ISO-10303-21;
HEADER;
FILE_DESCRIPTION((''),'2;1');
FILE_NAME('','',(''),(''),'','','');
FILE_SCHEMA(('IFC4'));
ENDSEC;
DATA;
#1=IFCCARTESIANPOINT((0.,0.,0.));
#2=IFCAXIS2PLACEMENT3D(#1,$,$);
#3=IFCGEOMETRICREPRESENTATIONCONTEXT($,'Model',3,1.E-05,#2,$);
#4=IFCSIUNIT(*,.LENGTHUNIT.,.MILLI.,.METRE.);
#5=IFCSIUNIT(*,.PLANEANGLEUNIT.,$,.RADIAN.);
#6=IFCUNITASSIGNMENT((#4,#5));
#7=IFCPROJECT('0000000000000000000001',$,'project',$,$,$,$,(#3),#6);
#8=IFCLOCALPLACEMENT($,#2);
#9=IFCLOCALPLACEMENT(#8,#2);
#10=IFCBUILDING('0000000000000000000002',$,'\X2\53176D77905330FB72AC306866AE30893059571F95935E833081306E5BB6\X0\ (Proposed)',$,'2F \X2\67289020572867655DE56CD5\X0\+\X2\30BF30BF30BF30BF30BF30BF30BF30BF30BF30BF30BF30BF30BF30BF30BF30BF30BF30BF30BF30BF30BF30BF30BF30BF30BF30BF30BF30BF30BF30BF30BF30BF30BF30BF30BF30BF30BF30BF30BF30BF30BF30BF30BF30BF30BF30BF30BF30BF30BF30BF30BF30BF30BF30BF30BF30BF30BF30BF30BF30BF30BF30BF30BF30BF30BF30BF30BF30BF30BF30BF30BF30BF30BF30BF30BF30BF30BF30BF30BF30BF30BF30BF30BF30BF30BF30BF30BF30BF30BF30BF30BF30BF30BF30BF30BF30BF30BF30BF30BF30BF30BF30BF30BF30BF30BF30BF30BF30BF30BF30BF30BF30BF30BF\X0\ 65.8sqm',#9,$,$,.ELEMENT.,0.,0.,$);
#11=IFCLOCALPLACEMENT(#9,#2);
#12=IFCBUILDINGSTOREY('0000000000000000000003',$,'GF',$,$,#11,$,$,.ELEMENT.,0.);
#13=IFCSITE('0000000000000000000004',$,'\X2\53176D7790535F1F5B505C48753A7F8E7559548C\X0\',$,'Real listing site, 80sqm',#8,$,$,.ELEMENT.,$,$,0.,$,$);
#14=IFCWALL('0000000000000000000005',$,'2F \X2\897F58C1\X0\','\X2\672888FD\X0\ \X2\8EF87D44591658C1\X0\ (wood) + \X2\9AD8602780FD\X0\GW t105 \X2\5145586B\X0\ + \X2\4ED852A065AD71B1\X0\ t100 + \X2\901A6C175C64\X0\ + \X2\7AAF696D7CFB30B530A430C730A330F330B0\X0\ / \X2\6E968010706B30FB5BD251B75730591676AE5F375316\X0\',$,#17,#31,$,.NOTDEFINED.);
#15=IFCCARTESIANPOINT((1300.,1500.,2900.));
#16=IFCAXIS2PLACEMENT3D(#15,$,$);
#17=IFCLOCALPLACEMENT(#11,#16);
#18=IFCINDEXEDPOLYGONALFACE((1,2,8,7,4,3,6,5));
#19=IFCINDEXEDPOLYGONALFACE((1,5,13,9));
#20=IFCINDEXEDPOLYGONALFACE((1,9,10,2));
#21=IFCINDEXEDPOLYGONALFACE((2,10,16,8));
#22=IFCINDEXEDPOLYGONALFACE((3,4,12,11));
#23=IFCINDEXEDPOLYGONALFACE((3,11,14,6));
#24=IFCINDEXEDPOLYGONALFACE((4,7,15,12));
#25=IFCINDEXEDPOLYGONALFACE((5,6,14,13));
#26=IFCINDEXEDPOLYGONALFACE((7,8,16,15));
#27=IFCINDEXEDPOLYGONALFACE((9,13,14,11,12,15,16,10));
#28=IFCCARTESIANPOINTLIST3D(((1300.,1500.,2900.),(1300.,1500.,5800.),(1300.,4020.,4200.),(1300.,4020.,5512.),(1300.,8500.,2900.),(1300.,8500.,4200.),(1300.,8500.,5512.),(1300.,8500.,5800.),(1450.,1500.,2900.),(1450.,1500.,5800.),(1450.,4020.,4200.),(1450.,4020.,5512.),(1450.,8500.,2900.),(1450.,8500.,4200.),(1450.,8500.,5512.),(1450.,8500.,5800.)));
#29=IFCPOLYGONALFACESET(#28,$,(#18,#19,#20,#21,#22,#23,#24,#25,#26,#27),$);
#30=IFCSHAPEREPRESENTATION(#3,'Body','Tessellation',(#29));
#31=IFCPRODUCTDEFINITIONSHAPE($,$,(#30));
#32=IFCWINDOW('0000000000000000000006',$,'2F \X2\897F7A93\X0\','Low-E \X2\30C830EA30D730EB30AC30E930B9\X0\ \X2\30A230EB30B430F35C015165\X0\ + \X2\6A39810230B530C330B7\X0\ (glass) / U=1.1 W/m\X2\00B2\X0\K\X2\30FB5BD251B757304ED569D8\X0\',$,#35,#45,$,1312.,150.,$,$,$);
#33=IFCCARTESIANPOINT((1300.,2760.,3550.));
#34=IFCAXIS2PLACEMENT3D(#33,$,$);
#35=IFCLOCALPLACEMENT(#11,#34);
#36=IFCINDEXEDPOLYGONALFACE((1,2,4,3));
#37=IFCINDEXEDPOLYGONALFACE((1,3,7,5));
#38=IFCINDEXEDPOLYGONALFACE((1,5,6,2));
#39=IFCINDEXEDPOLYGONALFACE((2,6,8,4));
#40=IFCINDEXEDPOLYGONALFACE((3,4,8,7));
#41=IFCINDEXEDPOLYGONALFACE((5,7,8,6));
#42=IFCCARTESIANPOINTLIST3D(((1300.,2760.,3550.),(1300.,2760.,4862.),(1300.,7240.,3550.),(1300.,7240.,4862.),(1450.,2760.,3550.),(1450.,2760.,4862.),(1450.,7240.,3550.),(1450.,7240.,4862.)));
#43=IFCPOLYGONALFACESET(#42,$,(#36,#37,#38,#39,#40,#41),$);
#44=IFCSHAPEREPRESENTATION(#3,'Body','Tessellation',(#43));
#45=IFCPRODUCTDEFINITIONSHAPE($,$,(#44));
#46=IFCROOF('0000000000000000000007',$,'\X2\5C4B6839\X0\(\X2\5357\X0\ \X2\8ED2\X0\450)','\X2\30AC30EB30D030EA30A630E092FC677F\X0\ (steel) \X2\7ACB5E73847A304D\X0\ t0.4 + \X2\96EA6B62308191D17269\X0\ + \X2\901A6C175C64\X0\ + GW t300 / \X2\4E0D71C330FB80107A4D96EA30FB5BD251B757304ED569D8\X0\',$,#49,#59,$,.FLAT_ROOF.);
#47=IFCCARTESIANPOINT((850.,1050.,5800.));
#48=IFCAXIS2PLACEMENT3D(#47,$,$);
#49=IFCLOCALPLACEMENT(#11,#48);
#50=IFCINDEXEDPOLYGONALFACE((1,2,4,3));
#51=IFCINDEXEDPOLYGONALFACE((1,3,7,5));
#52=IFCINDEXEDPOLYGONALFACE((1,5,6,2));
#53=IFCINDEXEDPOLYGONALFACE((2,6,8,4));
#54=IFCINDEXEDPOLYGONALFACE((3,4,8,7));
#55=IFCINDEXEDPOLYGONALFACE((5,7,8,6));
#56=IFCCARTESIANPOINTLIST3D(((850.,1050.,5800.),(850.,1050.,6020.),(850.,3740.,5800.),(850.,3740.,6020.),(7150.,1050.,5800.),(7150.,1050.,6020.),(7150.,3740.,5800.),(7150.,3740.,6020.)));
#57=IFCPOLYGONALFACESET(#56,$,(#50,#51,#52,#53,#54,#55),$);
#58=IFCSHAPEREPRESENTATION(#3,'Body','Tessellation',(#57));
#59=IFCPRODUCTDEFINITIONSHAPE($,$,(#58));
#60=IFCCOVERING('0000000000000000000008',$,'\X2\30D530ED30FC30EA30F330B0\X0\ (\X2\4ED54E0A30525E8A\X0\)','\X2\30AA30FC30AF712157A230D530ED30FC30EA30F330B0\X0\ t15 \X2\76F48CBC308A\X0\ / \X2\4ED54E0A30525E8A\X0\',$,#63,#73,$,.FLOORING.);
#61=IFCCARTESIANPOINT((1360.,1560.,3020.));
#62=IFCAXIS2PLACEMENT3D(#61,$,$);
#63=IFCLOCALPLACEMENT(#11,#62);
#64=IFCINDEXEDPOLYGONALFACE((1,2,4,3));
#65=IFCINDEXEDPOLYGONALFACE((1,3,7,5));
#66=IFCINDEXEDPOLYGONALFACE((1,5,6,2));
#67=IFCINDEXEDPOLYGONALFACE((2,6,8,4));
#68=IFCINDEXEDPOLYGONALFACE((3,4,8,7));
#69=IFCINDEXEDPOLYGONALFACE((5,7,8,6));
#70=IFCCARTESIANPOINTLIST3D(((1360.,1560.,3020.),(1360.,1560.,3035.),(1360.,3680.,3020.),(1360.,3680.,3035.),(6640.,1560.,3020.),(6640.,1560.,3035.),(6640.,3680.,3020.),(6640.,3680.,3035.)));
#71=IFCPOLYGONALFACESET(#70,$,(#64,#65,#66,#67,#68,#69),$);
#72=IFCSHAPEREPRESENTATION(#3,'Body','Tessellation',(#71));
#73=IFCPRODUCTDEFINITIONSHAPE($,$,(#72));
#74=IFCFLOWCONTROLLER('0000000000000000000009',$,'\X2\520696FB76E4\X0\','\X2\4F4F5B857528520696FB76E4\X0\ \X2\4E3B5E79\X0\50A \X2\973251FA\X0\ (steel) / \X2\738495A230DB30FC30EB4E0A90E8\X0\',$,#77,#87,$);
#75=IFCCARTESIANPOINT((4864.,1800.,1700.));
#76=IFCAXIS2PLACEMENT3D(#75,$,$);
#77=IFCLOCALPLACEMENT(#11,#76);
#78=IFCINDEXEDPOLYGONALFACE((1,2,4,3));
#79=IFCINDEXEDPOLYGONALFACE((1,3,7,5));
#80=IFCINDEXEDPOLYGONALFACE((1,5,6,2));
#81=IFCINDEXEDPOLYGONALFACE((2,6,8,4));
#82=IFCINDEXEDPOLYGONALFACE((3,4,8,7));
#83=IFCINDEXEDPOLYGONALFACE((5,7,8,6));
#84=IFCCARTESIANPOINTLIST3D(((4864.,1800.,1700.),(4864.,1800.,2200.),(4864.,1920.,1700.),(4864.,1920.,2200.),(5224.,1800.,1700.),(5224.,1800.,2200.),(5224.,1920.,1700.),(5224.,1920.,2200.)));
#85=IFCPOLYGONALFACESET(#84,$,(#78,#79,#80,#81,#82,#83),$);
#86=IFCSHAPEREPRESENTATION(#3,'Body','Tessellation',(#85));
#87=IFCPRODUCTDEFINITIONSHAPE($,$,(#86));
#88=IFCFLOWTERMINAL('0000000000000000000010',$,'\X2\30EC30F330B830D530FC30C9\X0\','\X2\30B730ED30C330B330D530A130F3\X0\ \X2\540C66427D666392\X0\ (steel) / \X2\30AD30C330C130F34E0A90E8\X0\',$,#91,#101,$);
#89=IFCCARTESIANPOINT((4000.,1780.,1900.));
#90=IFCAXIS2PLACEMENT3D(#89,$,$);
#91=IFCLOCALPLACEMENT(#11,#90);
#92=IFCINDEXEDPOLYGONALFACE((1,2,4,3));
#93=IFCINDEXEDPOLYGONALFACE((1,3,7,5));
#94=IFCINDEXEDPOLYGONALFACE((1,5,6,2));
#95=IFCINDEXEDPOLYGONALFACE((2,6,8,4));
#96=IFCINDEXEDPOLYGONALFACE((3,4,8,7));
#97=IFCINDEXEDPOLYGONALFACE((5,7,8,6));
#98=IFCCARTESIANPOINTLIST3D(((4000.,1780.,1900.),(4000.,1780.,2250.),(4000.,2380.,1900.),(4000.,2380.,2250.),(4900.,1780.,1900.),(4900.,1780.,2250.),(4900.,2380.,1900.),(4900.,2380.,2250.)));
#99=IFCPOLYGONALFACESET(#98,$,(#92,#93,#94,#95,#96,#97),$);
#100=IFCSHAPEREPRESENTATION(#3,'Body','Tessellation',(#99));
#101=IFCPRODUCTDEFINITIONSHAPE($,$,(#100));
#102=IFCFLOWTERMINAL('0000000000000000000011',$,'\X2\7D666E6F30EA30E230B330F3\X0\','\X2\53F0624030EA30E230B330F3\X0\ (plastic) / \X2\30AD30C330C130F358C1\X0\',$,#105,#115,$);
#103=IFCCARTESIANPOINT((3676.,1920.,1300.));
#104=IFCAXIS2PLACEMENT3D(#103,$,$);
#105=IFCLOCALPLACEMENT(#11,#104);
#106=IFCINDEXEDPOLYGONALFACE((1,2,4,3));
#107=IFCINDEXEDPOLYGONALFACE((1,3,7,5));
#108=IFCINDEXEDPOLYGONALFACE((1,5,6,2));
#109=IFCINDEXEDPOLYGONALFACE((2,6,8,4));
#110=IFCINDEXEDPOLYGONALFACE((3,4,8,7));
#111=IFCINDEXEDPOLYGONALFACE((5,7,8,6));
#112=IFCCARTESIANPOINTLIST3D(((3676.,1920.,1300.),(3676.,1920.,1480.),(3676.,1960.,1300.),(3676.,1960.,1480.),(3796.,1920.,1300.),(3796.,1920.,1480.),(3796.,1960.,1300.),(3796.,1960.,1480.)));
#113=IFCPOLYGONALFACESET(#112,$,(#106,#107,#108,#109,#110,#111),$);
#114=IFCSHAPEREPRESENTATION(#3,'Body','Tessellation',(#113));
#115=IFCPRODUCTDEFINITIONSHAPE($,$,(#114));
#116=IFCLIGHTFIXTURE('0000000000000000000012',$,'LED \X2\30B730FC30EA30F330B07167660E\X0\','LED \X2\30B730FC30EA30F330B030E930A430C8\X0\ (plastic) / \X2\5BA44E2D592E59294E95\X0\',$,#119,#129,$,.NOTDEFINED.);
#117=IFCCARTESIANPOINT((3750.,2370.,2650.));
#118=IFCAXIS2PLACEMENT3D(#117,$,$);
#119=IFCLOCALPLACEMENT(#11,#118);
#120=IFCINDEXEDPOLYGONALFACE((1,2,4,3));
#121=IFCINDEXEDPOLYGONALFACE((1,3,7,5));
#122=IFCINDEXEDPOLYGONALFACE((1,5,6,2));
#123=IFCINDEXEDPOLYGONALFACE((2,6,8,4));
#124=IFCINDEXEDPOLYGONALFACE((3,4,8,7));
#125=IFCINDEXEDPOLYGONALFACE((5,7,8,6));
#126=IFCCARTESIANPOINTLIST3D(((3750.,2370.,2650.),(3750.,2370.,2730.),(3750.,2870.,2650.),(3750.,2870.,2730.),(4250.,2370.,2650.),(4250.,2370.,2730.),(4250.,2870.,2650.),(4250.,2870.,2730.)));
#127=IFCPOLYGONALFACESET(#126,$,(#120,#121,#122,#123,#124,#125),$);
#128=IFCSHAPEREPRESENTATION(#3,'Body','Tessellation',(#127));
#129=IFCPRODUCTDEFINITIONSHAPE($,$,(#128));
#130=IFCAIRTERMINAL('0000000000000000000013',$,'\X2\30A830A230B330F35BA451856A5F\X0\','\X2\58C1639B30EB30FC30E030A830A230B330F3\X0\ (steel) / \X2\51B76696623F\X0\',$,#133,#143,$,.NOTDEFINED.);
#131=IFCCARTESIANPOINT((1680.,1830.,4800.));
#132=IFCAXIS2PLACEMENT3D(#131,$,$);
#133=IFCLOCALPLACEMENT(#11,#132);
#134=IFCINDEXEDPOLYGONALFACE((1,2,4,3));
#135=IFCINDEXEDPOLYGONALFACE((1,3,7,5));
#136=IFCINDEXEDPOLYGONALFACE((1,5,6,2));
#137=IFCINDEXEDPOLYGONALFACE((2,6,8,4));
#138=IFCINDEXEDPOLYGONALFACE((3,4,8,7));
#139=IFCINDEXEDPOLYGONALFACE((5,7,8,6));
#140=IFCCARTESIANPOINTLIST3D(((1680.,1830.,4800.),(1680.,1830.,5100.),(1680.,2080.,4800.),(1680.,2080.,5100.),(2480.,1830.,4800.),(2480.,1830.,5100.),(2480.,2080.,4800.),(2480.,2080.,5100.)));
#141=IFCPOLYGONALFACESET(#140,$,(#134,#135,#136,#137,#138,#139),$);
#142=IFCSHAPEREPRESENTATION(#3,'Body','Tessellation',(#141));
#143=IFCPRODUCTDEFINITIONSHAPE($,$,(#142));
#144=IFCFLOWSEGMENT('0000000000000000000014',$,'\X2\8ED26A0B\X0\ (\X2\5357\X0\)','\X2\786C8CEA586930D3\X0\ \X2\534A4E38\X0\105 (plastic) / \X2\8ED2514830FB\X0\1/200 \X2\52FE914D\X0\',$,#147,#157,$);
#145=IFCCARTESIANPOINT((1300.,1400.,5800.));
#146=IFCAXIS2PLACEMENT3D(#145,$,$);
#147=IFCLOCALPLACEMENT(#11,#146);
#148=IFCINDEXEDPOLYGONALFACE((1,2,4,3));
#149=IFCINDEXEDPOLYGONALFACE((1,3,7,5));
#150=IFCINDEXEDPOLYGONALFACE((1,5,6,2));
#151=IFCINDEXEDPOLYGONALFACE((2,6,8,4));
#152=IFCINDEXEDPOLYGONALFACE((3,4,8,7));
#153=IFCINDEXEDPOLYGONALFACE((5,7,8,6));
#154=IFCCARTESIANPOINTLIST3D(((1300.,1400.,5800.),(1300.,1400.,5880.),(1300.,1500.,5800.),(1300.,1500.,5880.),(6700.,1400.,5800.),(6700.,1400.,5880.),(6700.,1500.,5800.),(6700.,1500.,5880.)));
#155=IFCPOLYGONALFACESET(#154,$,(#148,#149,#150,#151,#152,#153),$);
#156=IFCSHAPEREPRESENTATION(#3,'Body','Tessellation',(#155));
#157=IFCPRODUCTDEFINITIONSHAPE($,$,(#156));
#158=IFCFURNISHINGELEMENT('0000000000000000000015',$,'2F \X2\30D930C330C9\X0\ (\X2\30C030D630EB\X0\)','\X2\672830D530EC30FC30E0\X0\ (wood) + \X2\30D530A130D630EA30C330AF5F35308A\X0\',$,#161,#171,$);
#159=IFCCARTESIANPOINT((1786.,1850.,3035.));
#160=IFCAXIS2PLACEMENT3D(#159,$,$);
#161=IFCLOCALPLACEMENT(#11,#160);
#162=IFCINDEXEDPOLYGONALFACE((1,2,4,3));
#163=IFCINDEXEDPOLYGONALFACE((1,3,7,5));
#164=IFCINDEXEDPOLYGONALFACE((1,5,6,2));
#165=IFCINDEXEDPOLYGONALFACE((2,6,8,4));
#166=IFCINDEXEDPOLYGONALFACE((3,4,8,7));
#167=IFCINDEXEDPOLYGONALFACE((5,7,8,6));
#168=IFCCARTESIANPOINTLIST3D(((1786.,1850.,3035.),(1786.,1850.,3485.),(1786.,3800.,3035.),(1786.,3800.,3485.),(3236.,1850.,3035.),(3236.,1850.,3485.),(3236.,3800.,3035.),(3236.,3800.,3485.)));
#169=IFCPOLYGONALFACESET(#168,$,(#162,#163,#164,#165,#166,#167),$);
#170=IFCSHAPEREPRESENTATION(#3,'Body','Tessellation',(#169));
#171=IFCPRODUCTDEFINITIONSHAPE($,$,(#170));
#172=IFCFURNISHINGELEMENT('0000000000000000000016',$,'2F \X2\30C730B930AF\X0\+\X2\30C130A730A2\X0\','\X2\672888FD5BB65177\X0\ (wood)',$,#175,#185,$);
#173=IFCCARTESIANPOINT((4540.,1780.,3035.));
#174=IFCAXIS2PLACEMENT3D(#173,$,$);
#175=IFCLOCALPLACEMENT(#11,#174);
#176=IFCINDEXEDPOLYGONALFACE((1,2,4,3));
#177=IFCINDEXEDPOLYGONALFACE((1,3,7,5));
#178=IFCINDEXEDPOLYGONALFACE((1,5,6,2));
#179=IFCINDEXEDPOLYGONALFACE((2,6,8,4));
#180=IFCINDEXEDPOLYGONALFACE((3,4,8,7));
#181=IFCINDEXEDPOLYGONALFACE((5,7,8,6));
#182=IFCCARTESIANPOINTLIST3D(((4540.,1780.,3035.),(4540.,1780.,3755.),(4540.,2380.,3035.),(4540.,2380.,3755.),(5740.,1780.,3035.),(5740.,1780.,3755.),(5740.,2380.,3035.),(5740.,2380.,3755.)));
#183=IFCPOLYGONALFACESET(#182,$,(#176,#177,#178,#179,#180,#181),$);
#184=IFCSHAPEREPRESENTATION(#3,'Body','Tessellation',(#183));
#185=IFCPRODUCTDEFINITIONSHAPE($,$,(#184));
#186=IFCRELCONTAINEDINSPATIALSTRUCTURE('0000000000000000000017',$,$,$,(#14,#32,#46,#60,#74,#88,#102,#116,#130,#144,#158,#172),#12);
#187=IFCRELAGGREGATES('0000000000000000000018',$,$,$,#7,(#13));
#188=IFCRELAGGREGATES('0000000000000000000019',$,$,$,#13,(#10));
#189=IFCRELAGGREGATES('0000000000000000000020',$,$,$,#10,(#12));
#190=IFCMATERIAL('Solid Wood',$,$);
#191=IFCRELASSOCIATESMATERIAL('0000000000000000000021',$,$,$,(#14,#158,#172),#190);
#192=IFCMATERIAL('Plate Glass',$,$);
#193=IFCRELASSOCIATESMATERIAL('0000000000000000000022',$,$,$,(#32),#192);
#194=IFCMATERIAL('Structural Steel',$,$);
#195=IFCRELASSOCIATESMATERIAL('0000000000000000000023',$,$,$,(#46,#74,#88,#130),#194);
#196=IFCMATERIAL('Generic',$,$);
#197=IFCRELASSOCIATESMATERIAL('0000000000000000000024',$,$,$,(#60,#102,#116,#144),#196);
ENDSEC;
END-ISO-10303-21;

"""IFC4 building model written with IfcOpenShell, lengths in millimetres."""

from ifc_helpers import new_model, si_unit, frame, frame_2d, origin, place, context, project, spatial, rectangle, extrude, material, element, fill, save


model = new_model("IFC4")

# Units and contexts
model_context = context("Model", 3, precision=1e-05, world=origin())
ifc_project = project(units=[si_unit("LENGTHUNIT", "METRE", prefix="MILLI"), si_unit("PLANEANGLEUNIT", "RADIAN")], contexts=[model_context])

# Site, building, storey
site_placement = place(None, origin())
site = spatial("IfcSite", under=ifc_project, at=site_placement, Name="北海道弟子屈町美留和", ObjectType="Real listing site, 80sqm", CompositionType="ELEMENT", RefElevation=0.0)
building_placement = place(site_placement, origin())
building = spatial("IfcBuilding", under=site, at=building_placement, Name="北海道・犬と暮らす土間広めの家 (Proposed)", ObjectType="2F 木造在来工法+タタタタタタタタタタタタタタタタタタタタタタタタタタタタタタタタタタタタタタタタタタタタタタタタタタタタタタタタタタタタタタタタタタタタタタタタタタタタタタタタタタタタタタタタタタタタタタタタタタタタタタタタタタタタタタタタタ 65.8sqm", CompositionType="ELEMENT", ElevationOfRefHeight=0.0, ElevationOfTerrain=0.0)
storey_placement = place(building_placement, origin())
storey = spatial("IfcBuildingStorey", under=building, at=storey_placement, Name="GF", CompositionType="ELEMENT", Elevation=0.0)

# Shared definitions
ifc_material_1 = material(Name="Solid Wood")

# Wall, opening, window
ifc_material_2 = material(Name="Plate Glass")
wall_1_placement = place(storey_placement, frame((1300.0, 1500.0, 2900.0)))
wall_1 = element("IfcWall", 1, at=wall_1_placement, inside=storey, material=ifc_material_1, Name="2F 西壁", Description="木製 軸組外壁 (wood) + 高性能GW t105 充填 + 付加断熱 t100 + 通気層 + 窯業系サイディング / 準耐火・寒冷地外皮強化", PredefinedType="NOTDEFINED", context=model_context, shape_type="SweptSolid", body=[
    extrude(rectangle(XDim=150.0, YDim=7000.0, at=frame_2d((75.0, 3500.0))), frame((1300.0, 1500.0, 2900.0)), (0.0, 0.0, 1.0), 2900.0),
])
opening_1_placement = place(storey_placement, frame((1300.0, 2760.0, 3550.0)))
opening_1 = element("IfcOpeningElement", 2, at=opening_1_placement, cuts=wall_1, PredefinedType="NOTDEFINED", context=model_context, shape_type="SweptSolid", body=[
    extrude(rectangle(XDim=150.0, YDim=4480.0, at=frame_2d((75.0, 2240.0))), frame((1300.0, 2760.0, 3550.0)), (0.0, 0.0, 1.0), 1312.0),
])
window_1_placement = place(storey_placement, frame((1300.0, 2760.0, 3550.0)))
window_1 = element("IfcWindow", 3, at=window_1_placement, inside=storey, material=ifc_material_2, Name="2F 西窓", Description="Low-E トリプルガラス アルゴン封入 + 樹脂サッシ (glass) / U=1.1 W/m²K・寒冷地仕様", OverallHeight=1312.0, OverallWidth=150.0, context=model_context, shape_type="SweptSolid", body=[
    extrude(rectangle(XDim=150.0, YDim=4480.0, at=frame_2d((75.0, 2240.0))), frame((1300.0, 2760.0, 3550.0)), (0.0, 0.0, 1.0), 1312.0),
])
fill(opening_1, window_1)

# Roof
ifc_material_3 = material(Name="Structural Steel")
for number, where, name in (
    (4, (850.0, 1050.0, 5800.0), "屋根(南 軒450)"),
):
    element("IfcRoof", number, at=place(storey_placement, frame(where)), inside=storey, material=ifc_material_3, Name=name, Description="ガルバリウム鋼板 (steel) 立平葺き t0.4 + 雪止め金物 + 通気層 + GW t300 / 不燃・耐積雪・寒冷地仕様", PredefinedType="FLAT_ROOF", context=model_context, shape_type="SweptSolid", body=[
        extrude(rectangle(XDim=6300.0, YDim=2690.0, at=frame_2d((3150.0, 1345.0))), frame((850.0, 1050.0, 5800.0)), (0.0, 0.0, 1.0), 220.0),
    ])

# Covering
ifc_material_4 = material(Name="Generic")
covering_placement = place(storey_placement, frame((1360.0, 1560.0, 3020.0)))
element("IfcCovering", 5, at=covering_placement, inside=storey, material=ifc_material_4, Name="フローリング (仕上げ床)", Description="オーク無垢フローリング t15 直貼り / 仕上げ床", PredefinedType="FLOORING", context=model_context, shape_type="SweptSolid", body=[
    extrude(rectangle(XDim=5280.0, YDim=2120.0, at=frame_2d((2640.0, 1060.0))), frame((1360.0, 1560.0, 3020.0)), (0.0, 0.0, 1.0), 15.0),
])

# Flow controller
flow_controller_placement = place(storey_placement, frame((4864.0, 1800.0, 1700.0)))
element("IfcFlowController", 6, at=flow_controller_placement, inside=storey, material=ifc_material_3, Name="分電盤", Description="住宅用分電盤 主幹50A 露出 (steel) / 玄関ホール上部", context=model_context, shape_type="SweptSolid", body=[
    extrude(rectangle(XDim=360.0, YDim=120.0, at=frame_2d((180.0, 60.0))), frame((4864.0, 1800.0, 1700.0)), (0.0, 0.0, 1.0), 500.0),
])

# Flow terminals
flow_terminal_1_placement = place(storey_placement, frame((4000.0, 1780.0, 1900.0)))
element("IfcFlowTerminal", 7, at=flow_terminal_1_placement, inside=storey, material=ifc_material_3, Name="レンジフード", Description="シロッコファン 同時給排 (steel) / キッチン上部", context=model_context, shape_type="SweptSolid", body=[
    extrude(rectangle(XDim=900.0, YDim=600.0, at=frame_2d((450.0, 300.0))), frame((4000.0, 1780.0, 1900.0)), (0.0, 0.0, 1.0), 350.0),
])
flow_terminal_2_placement = place(storey_placement, frame((3676.0, 1920.0, 1300.0)))
element("IfcFlowTerminal", 8, at=flow_terminal_2_placement, inside=storey, material=ifc_material_4, Name="給湯リモコン", Description="台所リモコン (plastic) / キッチン壁", context=model_context, shape_type="SweptSolid", body=[
    extrude(rectangle(XDim=120.0, YDim=40.0, at=frame_2d((60.0, 20.0))), frame((3676.0, 1920.0, 1300.0)), (0.0, 0.0, 1.0), 180.0),
])

# Light fixture
light_fixture_placement = place(storey_placement, frame((3750.0, 2370.0, 2650.0)))
element("IfcLightFixture", 9, at=light_fixture_placement, inside=storey, material=ifc_material_4, Name="LED シーリング照明", Description="LED シーリングライト (plastic) / 室中央天井", PredefinedType="NOTDEFINED", context=model_context, shape_type="SweptSolid", body=[
    extrude(rectangle(XDim=500.0, YDim=500.0, at=frame_2d((250.0, 250.0))), frame((3750.0, 2370.0, 2650.0)), (0.0, 0.0, 1.0), 80.0),
])

# Air terminal
air_terminal_placement = place(storey_placement, frame((1680.0, 1830.0, 4800.0)))
element("IfcAirTerminal", 10, at=air_terminal_placement, inside=storey, material=ifc_material_3, Name="エアコン室内機", Description="壁掛ルームエアコン (steel) / 冷暖房", PredefinedType="NOTDEFINED", context=model_context, shape_type="SweptSolid", body=[
    extrude(rectangle(XDim=800.0, YDim=250.0, at=frame_2d((400.0, 125.0))), frame((1680.0, 1830.0, 4800.0)), (0.0, 0.0, 1.0), 300.0),
])

# Flow segment
flow_segment_placement = place(storey_placement, frame((1300.0, 1400.0, 5800.0)))
element("IfcFlowSegment", 11, at=flow_segment_placement, inside=storey, material=ifc_material_4, Name="軒樋 (南)", Description="硬質塩ビ 半丸105 (plastic) / 軒先・1/200 勾配", context=model_context, shape_type="SweptSolid", body=[
    extrude(rectangle(XDim=5400.0, YDim=100.0, at=frame_2d((2700.0, 50.0))), frame((1300.0, 1400.0, 5800.0)), (0.0, 0.0, 1.0), 80.0),
])

# Furnishing elements
furnishing_1_placement = place(storey_placement, frame((1786.0, 1850.0, 3035.0)))
element("IfcFurnishingElement", 12, at=furnishing_1_placement, inside=storey, material=ifc_material_1, Name="2F ベッド (ダブル)", Description="木フレーム (wood) + ファブリック張り", context=model_context, shape_type="SweptSolid", body=[
    extrude(rectangle(XDim=1450.0, YDim=1950.0, at=frame_2d((725.0, 975.0))), frame((1786.0, 1850.0, 3035.0)), (0.0, 0.0, 1.0), 450.0),
])
furnishing_2_placement = place(storey_placement, frame((4540.0, 1780.0, 3035.0)))
element("IfcFurnishingElement", 13, at=furnishing_2_placement, inside=storey, material=ifc_material_1, Name="2F デスク+チェア", Description="木製家具 (wood)", context=model_context, shape_type="SweptSolid", body=[
    extrude(rectangle(XDim=1200.0, YDim=600.0, at=frame_2d((600.0, 300.0))), frame((4540.0, 1780.0, 3035.0)), (0.0, 0.0, 1.0), 720.0),
])

save(model, "model.ifc")
